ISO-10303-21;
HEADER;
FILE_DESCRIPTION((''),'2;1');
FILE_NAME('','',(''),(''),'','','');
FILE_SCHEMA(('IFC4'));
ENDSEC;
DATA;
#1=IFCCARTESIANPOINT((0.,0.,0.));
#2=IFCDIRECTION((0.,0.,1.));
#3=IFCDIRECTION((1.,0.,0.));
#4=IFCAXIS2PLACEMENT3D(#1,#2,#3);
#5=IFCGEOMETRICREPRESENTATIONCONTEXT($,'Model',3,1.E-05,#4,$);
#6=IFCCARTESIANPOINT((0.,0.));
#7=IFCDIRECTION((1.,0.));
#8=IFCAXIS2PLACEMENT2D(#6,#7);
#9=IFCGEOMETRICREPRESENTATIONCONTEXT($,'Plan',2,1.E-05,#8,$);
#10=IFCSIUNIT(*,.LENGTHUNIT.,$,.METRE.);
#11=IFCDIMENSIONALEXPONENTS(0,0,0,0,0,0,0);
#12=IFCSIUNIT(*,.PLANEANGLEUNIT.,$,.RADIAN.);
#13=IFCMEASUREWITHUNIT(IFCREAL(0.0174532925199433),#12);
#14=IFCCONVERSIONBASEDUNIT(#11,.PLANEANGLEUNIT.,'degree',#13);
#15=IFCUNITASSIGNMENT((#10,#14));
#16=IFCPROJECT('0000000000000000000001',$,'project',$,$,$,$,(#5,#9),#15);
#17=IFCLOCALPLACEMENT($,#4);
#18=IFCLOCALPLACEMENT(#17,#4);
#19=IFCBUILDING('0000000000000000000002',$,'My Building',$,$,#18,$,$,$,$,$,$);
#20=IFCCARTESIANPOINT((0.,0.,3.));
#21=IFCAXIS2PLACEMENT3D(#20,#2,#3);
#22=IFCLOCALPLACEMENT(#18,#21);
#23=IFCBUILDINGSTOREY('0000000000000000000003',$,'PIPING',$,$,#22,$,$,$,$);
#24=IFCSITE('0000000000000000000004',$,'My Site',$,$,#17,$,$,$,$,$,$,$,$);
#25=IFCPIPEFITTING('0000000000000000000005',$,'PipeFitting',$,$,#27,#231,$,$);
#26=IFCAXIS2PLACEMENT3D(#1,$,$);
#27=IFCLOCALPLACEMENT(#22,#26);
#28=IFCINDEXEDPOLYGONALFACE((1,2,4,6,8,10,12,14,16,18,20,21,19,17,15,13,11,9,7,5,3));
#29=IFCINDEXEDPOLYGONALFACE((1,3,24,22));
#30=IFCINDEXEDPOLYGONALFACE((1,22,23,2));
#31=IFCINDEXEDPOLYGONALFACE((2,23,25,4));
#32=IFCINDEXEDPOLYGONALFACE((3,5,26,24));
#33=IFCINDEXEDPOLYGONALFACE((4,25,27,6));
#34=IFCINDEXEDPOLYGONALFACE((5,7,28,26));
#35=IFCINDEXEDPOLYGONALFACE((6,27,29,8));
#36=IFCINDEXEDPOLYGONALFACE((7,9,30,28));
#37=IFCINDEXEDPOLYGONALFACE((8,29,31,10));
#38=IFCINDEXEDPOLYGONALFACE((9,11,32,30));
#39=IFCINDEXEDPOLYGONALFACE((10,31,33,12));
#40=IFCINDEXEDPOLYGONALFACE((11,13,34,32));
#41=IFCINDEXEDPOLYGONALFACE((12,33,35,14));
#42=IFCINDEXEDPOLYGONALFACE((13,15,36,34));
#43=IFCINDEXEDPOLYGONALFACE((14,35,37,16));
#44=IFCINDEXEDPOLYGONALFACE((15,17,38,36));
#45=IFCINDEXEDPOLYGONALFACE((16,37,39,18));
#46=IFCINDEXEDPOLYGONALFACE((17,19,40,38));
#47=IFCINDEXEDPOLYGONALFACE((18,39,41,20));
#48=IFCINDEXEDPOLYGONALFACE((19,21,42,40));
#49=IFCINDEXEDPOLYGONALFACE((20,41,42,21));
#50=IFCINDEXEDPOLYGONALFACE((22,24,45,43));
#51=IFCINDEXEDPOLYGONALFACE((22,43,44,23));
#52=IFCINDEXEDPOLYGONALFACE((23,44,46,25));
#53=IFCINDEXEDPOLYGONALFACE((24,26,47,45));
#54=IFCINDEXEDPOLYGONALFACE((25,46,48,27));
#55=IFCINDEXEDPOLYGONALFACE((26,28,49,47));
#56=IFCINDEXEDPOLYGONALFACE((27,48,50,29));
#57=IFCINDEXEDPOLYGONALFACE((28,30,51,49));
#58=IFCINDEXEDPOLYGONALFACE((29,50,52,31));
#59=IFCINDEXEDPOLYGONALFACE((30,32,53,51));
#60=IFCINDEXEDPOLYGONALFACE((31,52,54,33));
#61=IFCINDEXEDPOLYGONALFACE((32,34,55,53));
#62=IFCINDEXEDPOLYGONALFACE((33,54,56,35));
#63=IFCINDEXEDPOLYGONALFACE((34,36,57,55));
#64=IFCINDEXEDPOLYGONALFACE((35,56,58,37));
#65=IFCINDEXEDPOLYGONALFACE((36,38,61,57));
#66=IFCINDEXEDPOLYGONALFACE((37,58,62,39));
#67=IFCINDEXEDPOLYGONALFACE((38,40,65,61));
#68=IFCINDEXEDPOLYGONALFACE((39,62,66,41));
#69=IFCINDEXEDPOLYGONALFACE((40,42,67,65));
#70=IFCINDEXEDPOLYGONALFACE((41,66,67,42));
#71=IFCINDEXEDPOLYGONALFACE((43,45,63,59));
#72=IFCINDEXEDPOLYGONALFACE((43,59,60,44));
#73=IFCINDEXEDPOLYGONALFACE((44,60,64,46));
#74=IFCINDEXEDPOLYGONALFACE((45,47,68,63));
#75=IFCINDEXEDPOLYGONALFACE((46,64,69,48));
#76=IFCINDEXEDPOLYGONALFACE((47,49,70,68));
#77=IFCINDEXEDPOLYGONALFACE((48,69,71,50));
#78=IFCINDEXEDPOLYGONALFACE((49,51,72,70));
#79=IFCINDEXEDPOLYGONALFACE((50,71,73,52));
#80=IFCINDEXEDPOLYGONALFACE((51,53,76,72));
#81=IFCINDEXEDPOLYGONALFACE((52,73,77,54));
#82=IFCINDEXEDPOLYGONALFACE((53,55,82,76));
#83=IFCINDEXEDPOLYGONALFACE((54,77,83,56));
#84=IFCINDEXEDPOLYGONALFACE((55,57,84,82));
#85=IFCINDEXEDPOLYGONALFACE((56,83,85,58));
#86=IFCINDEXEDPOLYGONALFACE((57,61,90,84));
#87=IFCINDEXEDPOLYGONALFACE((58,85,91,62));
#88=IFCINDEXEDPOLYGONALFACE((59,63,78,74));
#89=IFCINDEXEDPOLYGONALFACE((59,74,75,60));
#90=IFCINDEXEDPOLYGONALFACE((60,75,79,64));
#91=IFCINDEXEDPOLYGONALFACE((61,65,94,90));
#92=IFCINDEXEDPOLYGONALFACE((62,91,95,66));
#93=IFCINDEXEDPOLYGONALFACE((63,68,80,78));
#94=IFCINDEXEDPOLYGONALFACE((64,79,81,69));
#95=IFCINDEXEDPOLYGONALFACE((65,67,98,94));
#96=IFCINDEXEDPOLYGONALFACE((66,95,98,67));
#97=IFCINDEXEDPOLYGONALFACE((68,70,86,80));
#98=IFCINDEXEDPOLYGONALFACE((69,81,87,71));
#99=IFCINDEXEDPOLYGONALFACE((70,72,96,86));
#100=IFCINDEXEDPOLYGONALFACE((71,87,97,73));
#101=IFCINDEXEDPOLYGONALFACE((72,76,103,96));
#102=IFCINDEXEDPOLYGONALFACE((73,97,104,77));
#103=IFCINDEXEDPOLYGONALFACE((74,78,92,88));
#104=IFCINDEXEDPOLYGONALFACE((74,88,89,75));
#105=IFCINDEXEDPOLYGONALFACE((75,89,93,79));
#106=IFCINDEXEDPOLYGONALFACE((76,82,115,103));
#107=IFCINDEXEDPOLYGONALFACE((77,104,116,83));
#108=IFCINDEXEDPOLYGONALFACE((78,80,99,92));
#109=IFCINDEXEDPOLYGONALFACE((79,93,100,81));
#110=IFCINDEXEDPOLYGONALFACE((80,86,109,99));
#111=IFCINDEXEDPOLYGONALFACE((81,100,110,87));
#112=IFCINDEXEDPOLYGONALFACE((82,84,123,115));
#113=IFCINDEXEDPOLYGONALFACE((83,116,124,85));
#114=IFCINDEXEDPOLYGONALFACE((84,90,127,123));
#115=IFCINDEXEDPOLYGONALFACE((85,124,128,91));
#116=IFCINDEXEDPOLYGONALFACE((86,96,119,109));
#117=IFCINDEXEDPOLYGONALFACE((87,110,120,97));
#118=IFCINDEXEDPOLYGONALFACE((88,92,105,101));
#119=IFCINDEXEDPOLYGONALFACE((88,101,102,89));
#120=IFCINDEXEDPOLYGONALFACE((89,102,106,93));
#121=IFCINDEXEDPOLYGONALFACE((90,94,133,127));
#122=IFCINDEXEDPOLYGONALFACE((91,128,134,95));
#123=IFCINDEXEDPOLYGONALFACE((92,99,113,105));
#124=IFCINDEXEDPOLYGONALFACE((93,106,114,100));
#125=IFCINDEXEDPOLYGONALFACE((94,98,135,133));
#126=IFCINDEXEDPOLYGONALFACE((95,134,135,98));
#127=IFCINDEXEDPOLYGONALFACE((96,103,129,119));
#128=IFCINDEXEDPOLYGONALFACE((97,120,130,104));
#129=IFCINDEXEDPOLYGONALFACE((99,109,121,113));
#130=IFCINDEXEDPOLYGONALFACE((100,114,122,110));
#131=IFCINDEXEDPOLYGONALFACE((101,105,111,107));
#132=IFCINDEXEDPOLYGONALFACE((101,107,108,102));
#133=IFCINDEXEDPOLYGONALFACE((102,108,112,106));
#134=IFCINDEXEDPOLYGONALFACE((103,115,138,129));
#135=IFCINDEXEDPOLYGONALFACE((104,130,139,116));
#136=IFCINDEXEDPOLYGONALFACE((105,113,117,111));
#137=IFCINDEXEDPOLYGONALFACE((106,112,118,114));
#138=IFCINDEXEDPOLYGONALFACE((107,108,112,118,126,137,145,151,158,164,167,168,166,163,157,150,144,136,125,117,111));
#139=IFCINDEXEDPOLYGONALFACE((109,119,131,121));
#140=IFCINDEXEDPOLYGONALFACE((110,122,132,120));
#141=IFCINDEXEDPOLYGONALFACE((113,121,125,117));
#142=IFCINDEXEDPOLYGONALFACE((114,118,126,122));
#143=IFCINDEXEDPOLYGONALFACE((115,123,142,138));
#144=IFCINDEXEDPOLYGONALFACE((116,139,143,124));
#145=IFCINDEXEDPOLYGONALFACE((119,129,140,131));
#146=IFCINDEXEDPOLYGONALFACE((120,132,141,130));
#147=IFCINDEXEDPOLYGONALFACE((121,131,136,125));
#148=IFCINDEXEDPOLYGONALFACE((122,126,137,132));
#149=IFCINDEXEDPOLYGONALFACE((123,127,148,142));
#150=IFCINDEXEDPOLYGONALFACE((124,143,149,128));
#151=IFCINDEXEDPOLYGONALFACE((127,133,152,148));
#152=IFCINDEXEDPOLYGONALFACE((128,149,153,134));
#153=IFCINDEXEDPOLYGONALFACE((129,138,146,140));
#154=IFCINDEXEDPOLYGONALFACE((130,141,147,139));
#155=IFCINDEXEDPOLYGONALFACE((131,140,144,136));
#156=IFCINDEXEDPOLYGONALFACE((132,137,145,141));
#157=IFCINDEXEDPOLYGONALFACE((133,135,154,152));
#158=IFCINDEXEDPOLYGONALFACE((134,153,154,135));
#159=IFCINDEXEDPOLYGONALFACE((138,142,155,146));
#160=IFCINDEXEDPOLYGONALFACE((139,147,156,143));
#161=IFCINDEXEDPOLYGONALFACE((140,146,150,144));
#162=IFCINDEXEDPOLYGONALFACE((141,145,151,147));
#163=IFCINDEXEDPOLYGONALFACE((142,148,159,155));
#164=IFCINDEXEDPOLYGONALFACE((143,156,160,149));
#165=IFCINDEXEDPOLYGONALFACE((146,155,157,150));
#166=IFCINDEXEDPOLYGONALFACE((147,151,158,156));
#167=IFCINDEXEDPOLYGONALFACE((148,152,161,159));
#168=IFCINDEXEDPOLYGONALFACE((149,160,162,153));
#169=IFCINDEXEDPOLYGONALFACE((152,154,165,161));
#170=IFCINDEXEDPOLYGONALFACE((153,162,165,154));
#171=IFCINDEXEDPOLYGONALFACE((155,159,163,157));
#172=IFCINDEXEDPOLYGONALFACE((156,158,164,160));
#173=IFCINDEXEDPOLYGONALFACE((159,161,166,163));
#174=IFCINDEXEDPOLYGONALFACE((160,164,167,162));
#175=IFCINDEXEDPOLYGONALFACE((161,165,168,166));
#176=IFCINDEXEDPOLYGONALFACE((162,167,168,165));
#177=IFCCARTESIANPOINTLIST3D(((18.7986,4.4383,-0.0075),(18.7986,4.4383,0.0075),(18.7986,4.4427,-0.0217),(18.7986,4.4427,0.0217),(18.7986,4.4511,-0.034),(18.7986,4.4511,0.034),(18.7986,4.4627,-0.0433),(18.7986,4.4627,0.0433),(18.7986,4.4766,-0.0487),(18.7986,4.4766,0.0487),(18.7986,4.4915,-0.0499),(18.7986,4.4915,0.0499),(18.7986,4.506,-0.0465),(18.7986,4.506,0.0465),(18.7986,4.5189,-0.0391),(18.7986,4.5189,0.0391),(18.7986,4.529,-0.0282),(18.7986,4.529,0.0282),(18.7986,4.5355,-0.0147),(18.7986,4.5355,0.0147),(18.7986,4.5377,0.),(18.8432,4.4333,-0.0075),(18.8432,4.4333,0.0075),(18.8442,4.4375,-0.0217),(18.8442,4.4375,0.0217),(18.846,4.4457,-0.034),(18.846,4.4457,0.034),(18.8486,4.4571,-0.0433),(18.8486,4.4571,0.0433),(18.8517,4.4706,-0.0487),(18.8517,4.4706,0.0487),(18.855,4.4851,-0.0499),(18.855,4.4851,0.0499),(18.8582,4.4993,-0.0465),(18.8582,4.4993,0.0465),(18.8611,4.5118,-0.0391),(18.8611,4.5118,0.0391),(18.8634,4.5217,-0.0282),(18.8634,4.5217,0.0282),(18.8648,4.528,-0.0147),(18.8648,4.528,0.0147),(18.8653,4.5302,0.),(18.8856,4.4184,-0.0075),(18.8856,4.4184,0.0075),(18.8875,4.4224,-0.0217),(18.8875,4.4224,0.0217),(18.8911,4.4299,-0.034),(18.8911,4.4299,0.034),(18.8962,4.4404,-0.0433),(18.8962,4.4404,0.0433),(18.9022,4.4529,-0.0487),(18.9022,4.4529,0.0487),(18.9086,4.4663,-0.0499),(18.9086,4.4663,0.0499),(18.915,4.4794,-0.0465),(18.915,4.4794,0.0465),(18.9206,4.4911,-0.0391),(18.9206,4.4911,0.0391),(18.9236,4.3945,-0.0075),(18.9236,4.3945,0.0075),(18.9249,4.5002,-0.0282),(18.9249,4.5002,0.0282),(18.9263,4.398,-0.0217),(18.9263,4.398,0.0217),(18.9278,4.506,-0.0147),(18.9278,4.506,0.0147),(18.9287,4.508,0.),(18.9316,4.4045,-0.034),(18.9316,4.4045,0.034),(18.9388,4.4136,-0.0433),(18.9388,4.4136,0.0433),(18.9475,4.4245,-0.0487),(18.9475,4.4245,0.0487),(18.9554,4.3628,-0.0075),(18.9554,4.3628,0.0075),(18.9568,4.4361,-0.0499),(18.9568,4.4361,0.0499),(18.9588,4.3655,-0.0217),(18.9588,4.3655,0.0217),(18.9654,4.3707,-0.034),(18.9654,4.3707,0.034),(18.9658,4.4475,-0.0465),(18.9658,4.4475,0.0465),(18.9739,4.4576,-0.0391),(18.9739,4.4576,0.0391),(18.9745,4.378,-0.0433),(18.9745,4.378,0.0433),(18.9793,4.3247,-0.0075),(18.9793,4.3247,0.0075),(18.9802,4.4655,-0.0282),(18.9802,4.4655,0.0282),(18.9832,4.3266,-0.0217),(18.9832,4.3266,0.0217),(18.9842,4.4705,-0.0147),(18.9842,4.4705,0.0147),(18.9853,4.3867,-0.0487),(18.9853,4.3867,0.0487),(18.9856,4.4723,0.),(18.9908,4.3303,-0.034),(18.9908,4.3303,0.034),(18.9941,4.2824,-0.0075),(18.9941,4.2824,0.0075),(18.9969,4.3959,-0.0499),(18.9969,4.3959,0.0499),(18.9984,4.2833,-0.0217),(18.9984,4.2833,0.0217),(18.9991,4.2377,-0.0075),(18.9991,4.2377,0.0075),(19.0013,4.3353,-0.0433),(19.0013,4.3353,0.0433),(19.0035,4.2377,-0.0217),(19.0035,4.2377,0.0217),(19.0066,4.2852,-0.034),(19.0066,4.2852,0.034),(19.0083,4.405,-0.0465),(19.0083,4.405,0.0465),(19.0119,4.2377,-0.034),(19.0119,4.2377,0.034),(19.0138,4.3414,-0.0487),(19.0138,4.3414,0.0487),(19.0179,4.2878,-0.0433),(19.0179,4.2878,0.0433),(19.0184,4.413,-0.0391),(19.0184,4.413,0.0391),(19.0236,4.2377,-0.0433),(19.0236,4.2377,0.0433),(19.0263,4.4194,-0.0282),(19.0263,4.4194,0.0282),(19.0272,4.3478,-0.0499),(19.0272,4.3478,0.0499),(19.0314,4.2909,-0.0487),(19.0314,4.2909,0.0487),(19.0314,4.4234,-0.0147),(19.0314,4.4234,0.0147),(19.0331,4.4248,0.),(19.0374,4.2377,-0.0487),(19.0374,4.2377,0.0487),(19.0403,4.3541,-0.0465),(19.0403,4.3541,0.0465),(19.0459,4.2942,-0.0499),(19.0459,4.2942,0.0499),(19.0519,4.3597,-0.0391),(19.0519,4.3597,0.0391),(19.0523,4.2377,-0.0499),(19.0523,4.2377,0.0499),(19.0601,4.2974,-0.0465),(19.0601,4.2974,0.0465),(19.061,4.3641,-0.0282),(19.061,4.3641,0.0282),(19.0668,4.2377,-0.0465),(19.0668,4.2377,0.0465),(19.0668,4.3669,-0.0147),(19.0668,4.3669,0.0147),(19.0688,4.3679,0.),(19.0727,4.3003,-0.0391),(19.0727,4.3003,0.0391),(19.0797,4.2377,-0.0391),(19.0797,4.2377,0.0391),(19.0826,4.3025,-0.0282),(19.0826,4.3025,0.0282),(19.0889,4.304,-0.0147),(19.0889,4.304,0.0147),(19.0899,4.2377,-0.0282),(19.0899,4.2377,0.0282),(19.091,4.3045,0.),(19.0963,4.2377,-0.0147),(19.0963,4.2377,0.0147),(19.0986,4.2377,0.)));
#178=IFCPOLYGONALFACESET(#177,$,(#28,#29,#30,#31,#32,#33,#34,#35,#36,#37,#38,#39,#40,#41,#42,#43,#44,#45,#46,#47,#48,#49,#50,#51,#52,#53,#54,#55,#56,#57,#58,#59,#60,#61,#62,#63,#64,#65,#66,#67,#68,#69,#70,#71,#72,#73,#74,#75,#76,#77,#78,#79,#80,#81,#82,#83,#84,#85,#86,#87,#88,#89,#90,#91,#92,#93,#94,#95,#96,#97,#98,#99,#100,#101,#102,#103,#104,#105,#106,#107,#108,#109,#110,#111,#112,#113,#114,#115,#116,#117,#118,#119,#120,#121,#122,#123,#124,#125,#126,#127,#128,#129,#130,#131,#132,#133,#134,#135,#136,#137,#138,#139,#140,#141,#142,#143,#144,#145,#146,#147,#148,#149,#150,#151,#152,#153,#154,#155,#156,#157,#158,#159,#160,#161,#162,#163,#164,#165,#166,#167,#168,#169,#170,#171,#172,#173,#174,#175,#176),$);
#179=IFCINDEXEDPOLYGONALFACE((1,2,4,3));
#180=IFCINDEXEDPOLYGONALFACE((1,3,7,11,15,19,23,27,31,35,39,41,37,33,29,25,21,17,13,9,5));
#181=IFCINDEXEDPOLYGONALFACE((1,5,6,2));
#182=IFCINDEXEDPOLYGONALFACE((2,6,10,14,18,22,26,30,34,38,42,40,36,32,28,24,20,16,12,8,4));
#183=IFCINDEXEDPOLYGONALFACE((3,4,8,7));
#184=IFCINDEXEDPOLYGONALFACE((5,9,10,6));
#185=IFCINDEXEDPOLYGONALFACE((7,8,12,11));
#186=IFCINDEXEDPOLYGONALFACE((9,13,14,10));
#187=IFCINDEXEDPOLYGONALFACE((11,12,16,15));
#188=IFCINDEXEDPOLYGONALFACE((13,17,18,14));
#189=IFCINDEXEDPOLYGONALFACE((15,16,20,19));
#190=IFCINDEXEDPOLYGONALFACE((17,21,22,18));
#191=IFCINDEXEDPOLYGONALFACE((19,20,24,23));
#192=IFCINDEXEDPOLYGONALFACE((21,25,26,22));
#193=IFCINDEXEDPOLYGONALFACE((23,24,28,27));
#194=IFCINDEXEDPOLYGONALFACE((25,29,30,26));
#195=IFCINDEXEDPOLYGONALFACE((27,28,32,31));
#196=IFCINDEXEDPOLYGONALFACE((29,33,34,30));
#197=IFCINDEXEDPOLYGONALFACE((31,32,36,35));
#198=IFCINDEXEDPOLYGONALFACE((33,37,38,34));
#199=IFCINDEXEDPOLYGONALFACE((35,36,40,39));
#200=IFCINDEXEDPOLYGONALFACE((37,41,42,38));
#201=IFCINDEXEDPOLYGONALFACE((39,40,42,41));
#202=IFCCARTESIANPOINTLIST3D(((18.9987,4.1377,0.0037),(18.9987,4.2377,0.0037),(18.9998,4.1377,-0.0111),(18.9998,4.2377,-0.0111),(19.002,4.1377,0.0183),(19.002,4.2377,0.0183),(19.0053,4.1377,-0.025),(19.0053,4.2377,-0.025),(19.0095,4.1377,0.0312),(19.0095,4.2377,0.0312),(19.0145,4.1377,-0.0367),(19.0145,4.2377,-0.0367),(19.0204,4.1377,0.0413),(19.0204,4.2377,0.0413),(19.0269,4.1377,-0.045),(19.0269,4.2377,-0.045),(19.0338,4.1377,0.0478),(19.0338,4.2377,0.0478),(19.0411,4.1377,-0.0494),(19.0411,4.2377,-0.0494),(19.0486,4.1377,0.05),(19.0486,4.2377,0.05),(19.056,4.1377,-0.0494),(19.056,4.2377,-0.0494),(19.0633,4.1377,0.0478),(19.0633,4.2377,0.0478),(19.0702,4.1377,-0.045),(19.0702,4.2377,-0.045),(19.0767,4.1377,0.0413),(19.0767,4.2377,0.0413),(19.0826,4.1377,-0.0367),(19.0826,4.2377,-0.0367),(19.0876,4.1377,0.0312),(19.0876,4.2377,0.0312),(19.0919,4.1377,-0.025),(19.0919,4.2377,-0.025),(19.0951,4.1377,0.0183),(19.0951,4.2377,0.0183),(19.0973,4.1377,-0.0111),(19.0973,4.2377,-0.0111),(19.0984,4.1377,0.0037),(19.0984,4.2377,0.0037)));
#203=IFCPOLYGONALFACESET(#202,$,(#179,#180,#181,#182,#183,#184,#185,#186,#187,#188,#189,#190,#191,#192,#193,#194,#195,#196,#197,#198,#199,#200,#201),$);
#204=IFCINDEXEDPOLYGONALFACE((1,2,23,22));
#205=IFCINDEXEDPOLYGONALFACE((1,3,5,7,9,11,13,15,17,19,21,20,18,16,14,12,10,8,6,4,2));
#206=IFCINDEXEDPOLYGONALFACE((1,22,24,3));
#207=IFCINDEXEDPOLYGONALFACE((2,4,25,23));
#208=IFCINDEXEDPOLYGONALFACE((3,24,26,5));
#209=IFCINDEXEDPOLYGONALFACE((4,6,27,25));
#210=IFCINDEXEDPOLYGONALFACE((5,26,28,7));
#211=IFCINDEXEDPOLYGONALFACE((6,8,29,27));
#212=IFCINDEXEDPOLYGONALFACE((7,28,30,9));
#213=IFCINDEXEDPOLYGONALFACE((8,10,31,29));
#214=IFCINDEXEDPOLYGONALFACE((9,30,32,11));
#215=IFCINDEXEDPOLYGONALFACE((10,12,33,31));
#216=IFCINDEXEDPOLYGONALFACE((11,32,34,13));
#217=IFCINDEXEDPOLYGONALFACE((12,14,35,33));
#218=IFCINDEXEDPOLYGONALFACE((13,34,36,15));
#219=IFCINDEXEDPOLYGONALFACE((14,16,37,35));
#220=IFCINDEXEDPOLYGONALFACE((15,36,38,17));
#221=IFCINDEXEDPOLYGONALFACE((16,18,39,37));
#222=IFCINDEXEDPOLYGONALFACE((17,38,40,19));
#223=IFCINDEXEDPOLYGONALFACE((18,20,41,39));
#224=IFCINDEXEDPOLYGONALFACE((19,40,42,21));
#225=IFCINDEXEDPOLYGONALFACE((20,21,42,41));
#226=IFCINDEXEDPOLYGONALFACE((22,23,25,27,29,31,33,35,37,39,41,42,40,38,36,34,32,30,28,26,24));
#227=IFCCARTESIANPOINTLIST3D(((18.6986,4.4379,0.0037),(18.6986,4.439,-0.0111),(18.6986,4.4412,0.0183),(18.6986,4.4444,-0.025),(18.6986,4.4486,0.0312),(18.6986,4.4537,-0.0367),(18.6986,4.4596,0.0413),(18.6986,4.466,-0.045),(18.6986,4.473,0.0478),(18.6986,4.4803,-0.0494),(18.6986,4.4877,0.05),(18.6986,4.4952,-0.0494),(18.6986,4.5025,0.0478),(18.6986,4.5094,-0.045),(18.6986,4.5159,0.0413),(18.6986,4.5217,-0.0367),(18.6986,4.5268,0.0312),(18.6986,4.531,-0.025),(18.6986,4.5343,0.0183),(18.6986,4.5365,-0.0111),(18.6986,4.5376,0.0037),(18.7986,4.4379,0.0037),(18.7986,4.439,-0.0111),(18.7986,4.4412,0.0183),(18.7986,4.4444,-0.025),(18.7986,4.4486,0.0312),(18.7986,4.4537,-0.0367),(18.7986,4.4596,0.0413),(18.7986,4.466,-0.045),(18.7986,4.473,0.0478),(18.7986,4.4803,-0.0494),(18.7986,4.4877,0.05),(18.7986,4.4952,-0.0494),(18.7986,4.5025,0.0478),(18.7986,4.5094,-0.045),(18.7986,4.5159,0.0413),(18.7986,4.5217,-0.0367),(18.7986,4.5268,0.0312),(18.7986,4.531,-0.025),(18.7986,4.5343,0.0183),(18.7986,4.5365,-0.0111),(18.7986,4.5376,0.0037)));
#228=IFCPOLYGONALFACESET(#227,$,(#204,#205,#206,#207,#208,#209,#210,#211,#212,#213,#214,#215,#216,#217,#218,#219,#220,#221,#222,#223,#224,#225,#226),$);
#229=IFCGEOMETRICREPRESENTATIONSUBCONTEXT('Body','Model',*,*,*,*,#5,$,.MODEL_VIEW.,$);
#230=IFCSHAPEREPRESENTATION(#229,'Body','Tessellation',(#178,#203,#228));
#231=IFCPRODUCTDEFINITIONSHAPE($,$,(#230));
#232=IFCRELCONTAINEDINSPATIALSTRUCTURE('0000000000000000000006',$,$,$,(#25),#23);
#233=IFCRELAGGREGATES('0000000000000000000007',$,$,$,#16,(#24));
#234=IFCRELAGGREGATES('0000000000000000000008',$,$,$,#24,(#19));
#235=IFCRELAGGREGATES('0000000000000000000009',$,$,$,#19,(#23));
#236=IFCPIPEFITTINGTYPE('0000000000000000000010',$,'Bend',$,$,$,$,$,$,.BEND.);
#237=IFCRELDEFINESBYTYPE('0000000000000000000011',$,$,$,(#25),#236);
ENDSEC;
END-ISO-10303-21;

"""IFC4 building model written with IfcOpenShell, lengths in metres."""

from ifc_helpers import new_model, entity, si_unit, converted_unit, frame, origin_with_axes, origin_2d_with_axis, place, context, subcontext, project, spatial, circle, extrude, source, transform, mapped, type_object, type_shapes, element, save


model = new_model("IFC4")

# Units and contexts
model_context = context("Model", 3, precision=1e-05, world=origin_with_axes())
plan_context = context("Plan", 2, precision=1e-05, world=origin_2d_with_axis())
body_context = subcontext(model_context, "Body", "Model", "MODEL_VIEW")
ifc_project = project(units=[si_unit("LENGTHUNIT", "METRE"), converted_unit("PLANEANGLEUNIT", "degree", entity("IfcReal", 0.0174532925199433), si_unit("PLANEANGLEUNIT", "RADIAN"), dimensions=[0, 0, 0, 0, 0, 0, 0])], contexts=[model_context, plan_context])

# Site, building, storey
site_placement = place(None, origin_with_axes())
site = spatial("IfcSite", under=ifc_project, at=site_placement, Name="My Site")
building_placement = place(site_placement, origin_with_axes())
building = spatial("IfcBuilding", under=site, at=building_placement, Name="My Building")
storey_placement = place(building_placement, frame((0.0, 0.0, 3.0), z_axis=(0.0, 0.0, 1.0), x_axis=(1.0, 0.0, 0.0)))
storey = spatial("IfcBuildingStorey", under=building, at=storey_placement, Name="PIPING")

# Pipe fitting
pipe_fitting_type = type_object("IfcPipeFittingType", Name="Bend", PredefinedType="BEND")
shared_shape = source(origin_with_axes(), body_context, "Body", "SolidModel", [
    entity("IfcSweptDiskSolid", entity("IfcIndexedPolyCurve", entity("IfcCartesianPointList3D", [[0.0, 0.0, 0.1], [0.0, -0.0732, 0.2768], [0.0, -0.25, 0.35]]), [entity("IfcArcIndex", [1, 2, 3])]), 0.05),
    extrude(circle(Radius=0.05), origin_with_axes(), (0.0, 0.0, 1.0), 0.1),
    extrude(circle(Radius=0.05), frame((0.0, -0.25, 0.35), z_axis=(0.0, -1.0, 0.0), x_axis=(1.0, 0.0, 0.0)), (0.0, 0.0, 1.0), 0.1),
])
type_shapes(pipe_fitting_type, [shared_shape])
for number, where, z_axis, x_axis, name in (
    (1, (19.0486, 4.1377, 0.0), (0.0, 1.0, 0.0), (0.0, 0.0, 1.0), "PipeFitting"),
):
    element("IfcPipeFitting", number, at=place(storey_placement, frame(where, z_axis=z_axis, x_axis=x_axis)), inside=storey, type_object=pipe_fitting_type, Name=name, context=body_context, shape_type="MappedRepresentation", body=[
        mapped(shared_shape, transform((0.0, 0.0, 0.0), x_axis=(1.0, 0.0, 0.0), y_axis=(0.0, 1.0, 0.0), z_axis=(0.0, 0.0, 1.0), scale=1.0)),
    ])

save(model, "model.ifc")
